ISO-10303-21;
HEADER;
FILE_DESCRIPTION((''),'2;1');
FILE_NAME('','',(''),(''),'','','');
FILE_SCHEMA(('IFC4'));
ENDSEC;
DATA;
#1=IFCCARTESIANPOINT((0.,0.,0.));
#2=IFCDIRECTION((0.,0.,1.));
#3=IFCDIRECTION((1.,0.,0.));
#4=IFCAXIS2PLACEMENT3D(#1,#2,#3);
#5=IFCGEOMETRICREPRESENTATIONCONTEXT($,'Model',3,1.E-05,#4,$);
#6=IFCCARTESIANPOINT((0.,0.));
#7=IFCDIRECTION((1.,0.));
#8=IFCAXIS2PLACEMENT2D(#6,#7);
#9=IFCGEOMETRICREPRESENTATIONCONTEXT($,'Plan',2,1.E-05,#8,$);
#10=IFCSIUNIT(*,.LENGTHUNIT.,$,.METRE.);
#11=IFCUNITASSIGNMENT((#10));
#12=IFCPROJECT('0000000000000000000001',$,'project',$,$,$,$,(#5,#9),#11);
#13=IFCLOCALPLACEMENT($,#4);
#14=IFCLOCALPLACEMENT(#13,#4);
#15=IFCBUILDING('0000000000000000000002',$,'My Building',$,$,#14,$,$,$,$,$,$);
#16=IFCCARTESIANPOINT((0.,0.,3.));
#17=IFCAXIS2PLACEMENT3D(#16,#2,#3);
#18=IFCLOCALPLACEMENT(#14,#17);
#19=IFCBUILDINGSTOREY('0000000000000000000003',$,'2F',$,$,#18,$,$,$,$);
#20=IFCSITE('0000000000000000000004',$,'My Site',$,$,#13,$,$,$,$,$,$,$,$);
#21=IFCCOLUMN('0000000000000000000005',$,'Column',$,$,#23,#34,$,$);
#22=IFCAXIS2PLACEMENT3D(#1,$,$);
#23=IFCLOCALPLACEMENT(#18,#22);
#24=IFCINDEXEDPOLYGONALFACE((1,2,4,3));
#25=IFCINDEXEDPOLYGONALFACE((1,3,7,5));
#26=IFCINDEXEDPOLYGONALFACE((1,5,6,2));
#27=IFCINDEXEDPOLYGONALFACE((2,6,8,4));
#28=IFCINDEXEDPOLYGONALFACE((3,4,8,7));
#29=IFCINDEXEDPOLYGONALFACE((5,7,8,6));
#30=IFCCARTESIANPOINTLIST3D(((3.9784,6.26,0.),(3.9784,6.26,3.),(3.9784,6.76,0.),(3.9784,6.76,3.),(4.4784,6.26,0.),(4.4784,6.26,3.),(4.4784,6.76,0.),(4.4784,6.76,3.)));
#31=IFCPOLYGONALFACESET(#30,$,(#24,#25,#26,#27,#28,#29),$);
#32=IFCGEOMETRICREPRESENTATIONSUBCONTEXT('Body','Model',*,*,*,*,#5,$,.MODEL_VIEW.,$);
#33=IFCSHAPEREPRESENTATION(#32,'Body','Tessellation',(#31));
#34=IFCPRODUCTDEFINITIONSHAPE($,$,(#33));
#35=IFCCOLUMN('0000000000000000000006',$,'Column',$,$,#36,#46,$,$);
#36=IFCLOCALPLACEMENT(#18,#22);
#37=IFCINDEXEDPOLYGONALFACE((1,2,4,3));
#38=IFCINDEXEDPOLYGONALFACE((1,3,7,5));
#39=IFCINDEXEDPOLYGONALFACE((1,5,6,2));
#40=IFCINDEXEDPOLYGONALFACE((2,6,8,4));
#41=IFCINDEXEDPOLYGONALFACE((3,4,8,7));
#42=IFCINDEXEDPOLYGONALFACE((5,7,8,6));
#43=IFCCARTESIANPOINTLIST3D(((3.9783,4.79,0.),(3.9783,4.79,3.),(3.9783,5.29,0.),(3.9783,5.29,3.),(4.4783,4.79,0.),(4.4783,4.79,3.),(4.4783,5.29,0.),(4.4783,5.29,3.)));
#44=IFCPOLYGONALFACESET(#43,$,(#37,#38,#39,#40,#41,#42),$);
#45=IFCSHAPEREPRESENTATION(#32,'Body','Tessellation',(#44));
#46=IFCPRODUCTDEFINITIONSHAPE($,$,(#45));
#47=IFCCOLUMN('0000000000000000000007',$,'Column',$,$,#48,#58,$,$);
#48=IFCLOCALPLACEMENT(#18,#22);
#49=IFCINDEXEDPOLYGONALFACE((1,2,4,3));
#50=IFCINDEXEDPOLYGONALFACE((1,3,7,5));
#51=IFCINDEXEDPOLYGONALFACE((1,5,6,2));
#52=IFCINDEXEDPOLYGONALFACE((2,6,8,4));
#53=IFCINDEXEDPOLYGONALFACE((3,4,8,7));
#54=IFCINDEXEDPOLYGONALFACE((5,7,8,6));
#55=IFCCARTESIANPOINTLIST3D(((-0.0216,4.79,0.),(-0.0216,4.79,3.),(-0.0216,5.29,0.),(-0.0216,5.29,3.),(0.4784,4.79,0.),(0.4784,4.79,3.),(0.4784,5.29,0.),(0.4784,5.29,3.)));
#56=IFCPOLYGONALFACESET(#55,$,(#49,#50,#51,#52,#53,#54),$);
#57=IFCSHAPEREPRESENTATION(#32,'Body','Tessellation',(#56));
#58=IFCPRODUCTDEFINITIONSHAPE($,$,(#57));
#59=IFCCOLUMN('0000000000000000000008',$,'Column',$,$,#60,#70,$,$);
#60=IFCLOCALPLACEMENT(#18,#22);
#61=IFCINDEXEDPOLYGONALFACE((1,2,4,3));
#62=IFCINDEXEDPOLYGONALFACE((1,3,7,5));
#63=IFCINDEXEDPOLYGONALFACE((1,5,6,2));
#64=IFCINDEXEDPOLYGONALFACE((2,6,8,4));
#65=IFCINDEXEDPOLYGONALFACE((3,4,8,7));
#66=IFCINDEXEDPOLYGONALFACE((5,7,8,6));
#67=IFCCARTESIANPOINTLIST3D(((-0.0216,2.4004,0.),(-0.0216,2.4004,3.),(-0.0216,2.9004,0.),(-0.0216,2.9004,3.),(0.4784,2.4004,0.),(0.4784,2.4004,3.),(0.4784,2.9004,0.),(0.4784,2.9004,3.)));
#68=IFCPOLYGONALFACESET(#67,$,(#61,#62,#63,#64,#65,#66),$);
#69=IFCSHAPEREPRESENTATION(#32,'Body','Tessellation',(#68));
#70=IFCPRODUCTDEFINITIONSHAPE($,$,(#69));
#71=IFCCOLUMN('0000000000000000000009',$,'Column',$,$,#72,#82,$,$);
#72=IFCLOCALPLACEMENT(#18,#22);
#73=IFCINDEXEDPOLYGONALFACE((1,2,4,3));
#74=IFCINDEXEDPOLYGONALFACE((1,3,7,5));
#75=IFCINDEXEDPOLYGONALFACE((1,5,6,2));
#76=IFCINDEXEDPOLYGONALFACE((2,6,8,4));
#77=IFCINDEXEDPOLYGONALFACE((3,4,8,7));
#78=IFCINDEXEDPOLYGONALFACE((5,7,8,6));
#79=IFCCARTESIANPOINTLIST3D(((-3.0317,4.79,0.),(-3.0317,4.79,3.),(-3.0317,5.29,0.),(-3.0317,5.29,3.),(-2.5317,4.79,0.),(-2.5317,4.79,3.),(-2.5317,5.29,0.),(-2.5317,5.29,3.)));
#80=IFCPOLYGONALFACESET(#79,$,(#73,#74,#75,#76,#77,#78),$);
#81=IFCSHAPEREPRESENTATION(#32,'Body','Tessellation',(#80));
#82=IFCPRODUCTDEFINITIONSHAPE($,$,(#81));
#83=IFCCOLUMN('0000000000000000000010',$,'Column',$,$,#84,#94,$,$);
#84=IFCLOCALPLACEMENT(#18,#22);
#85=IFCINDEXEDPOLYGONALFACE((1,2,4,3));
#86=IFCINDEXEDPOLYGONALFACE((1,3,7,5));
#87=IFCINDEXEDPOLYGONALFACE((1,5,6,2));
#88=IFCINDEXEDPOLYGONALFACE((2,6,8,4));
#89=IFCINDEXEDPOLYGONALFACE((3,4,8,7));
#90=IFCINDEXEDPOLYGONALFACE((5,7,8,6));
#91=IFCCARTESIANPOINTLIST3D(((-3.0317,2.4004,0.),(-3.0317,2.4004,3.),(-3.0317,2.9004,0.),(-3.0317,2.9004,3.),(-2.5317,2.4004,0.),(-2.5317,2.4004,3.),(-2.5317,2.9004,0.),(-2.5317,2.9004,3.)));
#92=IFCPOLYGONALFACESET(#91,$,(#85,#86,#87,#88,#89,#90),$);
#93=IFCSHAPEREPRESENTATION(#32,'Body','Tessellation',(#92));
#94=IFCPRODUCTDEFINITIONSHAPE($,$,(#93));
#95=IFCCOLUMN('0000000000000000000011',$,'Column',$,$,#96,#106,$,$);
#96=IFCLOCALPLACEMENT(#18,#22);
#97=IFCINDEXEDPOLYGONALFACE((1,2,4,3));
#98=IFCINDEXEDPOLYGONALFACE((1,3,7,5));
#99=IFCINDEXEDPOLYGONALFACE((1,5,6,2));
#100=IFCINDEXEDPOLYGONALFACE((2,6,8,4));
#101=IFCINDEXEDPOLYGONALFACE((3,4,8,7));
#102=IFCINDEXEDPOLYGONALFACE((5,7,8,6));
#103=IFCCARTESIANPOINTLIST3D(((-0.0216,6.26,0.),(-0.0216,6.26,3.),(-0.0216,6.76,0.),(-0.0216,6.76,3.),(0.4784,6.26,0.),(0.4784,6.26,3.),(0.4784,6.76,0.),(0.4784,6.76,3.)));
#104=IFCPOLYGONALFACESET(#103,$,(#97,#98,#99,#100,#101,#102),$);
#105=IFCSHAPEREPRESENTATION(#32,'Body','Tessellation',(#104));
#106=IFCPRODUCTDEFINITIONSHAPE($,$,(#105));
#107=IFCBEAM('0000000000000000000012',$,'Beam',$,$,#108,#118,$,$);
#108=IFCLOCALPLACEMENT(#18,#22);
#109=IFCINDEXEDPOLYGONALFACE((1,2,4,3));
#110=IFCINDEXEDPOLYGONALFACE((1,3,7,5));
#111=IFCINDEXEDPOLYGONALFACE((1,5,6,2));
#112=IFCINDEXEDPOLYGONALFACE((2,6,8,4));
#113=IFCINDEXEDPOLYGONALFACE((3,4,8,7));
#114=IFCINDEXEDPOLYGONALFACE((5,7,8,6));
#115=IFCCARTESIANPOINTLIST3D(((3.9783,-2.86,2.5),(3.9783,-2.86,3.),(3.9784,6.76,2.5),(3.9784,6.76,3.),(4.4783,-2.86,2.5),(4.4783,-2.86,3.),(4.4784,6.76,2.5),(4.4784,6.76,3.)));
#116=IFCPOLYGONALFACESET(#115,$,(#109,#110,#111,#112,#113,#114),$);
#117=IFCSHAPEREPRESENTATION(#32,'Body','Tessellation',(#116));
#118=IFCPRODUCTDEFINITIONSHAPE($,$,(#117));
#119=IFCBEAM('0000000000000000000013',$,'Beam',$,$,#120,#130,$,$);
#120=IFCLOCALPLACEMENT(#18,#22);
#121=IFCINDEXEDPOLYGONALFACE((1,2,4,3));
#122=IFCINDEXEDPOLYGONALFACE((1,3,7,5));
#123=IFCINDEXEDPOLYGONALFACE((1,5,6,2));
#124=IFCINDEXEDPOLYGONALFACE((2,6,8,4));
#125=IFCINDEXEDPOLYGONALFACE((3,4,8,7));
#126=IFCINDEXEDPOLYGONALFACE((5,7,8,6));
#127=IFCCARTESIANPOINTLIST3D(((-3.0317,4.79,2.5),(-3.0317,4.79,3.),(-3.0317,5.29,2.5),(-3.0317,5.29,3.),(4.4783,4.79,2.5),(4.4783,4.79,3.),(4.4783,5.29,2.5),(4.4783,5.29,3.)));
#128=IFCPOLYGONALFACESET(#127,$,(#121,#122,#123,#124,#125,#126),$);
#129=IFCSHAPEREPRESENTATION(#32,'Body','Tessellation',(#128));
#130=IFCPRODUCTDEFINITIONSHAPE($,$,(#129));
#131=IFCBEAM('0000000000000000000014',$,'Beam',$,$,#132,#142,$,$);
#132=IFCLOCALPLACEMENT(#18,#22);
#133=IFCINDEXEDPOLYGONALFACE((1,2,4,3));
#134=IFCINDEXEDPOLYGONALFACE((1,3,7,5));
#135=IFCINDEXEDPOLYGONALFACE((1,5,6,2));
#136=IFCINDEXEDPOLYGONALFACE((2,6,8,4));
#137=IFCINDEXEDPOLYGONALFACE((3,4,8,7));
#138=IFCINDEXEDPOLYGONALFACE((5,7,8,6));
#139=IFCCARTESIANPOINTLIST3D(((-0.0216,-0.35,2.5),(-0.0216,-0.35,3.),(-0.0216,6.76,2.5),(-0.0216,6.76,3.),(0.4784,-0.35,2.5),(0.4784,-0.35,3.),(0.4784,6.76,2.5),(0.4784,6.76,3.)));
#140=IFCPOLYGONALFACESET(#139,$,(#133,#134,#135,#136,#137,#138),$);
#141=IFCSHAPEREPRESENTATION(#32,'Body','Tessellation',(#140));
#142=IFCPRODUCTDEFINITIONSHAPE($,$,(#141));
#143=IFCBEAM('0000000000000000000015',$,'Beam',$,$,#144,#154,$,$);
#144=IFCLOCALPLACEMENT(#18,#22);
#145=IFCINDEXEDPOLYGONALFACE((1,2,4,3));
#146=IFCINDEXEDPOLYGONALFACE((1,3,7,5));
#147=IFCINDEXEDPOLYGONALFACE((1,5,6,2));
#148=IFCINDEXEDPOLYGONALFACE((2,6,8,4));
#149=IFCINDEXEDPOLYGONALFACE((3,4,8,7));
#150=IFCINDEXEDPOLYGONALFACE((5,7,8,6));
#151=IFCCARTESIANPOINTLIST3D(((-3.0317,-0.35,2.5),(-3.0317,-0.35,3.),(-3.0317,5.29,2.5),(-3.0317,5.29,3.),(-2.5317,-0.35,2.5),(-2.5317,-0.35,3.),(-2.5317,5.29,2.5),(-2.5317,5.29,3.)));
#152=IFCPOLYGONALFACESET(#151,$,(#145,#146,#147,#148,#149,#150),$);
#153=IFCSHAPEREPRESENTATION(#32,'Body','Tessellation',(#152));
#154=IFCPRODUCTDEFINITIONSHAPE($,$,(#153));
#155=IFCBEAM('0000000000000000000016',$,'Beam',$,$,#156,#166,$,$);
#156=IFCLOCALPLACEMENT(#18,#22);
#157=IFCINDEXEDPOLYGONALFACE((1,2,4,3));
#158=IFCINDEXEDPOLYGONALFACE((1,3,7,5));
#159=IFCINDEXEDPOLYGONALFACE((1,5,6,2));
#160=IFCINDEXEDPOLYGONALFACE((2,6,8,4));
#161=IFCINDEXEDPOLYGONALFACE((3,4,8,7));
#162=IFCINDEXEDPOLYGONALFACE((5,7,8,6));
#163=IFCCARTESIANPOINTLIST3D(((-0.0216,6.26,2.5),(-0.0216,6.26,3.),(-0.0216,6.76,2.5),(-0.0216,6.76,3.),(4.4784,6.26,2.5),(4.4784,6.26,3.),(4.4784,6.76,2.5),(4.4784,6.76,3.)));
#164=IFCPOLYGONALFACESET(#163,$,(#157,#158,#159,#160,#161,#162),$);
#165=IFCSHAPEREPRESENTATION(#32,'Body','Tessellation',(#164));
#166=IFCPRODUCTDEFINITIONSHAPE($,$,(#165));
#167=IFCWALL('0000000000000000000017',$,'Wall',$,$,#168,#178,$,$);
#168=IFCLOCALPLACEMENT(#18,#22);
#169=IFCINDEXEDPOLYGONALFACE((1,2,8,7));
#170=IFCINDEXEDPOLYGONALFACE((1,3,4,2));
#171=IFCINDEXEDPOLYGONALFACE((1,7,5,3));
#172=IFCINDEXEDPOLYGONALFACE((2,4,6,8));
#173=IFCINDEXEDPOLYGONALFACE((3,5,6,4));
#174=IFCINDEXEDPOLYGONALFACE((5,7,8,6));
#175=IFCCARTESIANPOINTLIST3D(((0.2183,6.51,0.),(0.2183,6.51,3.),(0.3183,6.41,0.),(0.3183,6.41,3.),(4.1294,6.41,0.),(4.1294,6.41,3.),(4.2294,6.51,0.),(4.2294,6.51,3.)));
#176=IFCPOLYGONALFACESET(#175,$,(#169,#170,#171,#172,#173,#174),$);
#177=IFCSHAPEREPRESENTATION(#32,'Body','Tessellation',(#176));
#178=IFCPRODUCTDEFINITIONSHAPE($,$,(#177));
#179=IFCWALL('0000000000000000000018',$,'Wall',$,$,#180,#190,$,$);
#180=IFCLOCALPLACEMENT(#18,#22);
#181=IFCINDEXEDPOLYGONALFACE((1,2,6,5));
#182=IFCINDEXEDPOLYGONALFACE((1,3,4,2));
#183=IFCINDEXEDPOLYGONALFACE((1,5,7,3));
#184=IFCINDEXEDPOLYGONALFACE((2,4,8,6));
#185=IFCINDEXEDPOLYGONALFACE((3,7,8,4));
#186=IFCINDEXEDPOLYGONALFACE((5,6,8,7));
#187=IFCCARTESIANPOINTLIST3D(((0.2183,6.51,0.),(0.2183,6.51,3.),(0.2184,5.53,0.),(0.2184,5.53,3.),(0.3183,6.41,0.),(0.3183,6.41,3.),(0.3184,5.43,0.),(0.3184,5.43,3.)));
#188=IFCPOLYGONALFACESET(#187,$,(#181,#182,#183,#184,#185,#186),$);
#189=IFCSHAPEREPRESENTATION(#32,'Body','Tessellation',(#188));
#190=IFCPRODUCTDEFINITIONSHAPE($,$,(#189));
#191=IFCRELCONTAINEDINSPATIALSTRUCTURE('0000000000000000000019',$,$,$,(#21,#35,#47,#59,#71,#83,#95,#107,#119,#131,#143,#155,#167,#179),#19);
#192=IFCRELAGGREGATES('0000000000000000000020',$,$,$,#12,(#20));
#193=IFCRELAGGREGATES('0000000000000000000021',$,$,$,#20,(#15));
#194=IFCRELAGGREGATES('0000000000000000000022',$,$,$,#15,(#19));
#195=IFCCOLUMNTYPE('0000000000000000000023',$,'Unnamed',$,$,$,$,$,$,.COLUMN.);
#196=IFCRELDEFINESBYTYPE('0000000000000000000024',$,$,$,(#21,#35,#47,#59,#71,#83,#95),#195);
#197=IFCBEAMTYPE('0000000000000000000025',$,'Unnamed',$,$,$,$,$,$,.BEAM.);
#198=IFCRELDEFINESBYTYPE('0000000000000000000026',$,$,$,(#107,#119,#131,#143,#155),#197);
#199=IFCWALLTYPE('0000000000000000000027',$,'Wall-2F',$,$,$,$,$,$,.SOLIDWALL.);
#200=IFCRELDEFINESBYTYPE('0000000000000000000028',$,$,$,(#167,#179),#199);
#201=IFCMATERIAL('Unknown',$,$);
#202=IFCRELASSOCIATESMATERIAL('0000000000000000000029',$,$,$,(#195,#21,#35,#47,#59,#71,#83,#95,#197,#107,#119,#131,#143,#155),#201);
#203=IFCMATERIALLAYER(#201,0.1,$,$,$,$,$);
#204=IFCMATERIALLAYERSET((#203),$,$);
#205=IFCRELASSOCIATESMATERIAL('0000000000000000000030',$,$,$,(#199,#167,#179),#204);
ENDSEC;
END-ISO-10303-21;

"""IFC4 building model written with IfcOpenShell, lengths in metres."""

from ifc_helpers import new_model, si_unit, frame, origin_with_axes, origin_2d_with_axis, place, context, subcontext, project, spatial, line, indexed_curve, rectangle, outline, extrude, material, layer, layer_set, layer_usage, material_profile, profile_set, profile_usage, type_object, element, save


model = new_model("IFC4")

# Units and contexts
model_context = context("Model", 3, precision=1e-05, world=origin_with_axes())
plan_context = context("Plan", 2, precision=1e-05, world=origin_2d_with_axis())
body_context_1 = subcontext(model_context, "Body", "Model", "MODEL_VIEW")
ifc_project = project(units=[si_unit("LENGTHUNIT", "METRE")], contexts=[model_context, plan_context])

# Site, building, storey
site_placement = place(None, origin_with_axes())
site = spatial("IfcSite", under=ifc_project, at=site_placement, Name="My Site")
building_placement = place(site_placement, origin_with_axes())
building = spatial("IfcBuilding", under=site, at=building_placement, Name="My Building")
storey_placement = place(building_placement, frame((0.0, 0.0, 3.0), z_axis=(0.0, 0.0, 1.0), x_axis=(1.0, 0.0, 0.0)))
storey = spatial("IfcBuildingStorey", under=building, at=storey_placement, Name="2F")

# Columns
ifc_material = material(Name="Unknown")
ifc_material_profile_1 = material_profile(ifc_material, rectangle(XDim=0.5, YDim=0.5))
ifc_profile_set_1 = profile_set([ifc_material_profile_1])
ifc_profile_usage_1 = profile_usage(ifc_profile_set_1, cardinal=7)
column_type = type_object("IfcColumnType", Name="Unnamed", PredefinedType="COLUMN", material=ifc_profile_set_1)
column_1_placement = place(storey_placement, frame((4.4784, 6.76, 0.0), z_axis=(0.0, 0.0, 1.0), x_axis=(1.0, 0.0, 0.0)))
element("IfcColumn", 1, at=column_1_placement, inside=storey, type_object=column_type, material=ifc_profile_usage_1, Name="Column", context=body_context_1, shape_type="SweptSolid", body=[
    extrude(rectangle(XDim=0.5, YDim=0.5), frame((-0.25, -0.25, 0.0), z_axis=(0.0, 0.0, 1.0), x_axis=(1.0, 0.0, 0.0)), (0.0, 0.0, 1.0), 3.0),
])
ifc_profile_usage_2 = profile_usage(ifc_profile_set_1, cardinal=7)
column_2_placement = place(storey_placement, frame((4.4783, 5.29, 0.0), z_axis=(0.0, 0.0, 1.0), x_axis=(1.0, 0.0, 0.0)))
element("IfcColumn", 2, at=column_2_placement, inside=storey, type_object=column_type, material=ifc_profile_usage_2, Name="Column", context=body_context_1, shape_type="SweptSolid", body=[
    extrude(rectangle(XDim=0.5, YDim=0.5), frame((-0.25, -0.25, 0.0), z_axis=(0.0, 0.0, 1.0), x_axis=(1.0, 0.0, 0.0)), (0.0, 0.0, 1.0), 3.0),
])
ifc_profile_usage_3 = profile_usage(ifc_profile_set_1, cardinal=7)
column_3_placement = place(storey_placement, frame((0.4784, 5.29, 0.0), z_axis=(0.0, 0.0, 1.0), x_axis=(1.0, 0.0, 0.0)))
element("IfcColumn", 3, at=column_3_placement, inside=storey, type_object=column_type, material=ifc_profile_usage_3, Name="Column", context=body_context_1, shape_type="SweptSolid", body=[
    extrude(rectangle(XDim=0.5, YDim=0.5), frame((-0.25, -0.25, 0.0), z_axis=(0.0, 0.0, 1.0), x_axis=(1.0, 0.0, 0.0)), (0.0, 0.0, 1.0), 3.0),
])
ifc_profile_usage_4 = profile_usage(ifc_profile_set_1, cardinal=7)
column_4_placement = place(storey_placement, frame((0.4784, 2.9004, 0.0), z_axis=(0.0, 0.0, 1.0), x_axis=(1.0, 0.0, 0.0)))
element("IfcColumn", 4, at=column_4_placement, inside=storey, type_object=column_type, material=ifc_profile_usage_4, Name="Column", context=body_context_1, shape_type="SweptSolid", body=[
    extrude(rectangle(XDim=0.5, YDim=0.5), frame((-0.25, -0.25, 0.0), z_axis=(0.0, 0.0, 1.0), x_axis=(1.0, 0.0, 0.0)), (0.0, 0.0, 1.0), 3.0),
])
ifc_profile_usage_5 = profile_usage(ifc_profile_set_1, cardinal=7)
column_5_placement = place(storey_placement, frame((-2.5317, 5.29, 0.0), z_axis=(0.0, 0.0, 1.0), x_axis=(1.0, 0.0, 0.0)))
element("IfcColumn", 5, at=column_5_placement, inside=storey, type_object=column_type, material=ifc_profile_usage_5, Name="Column", context=body_context_1, shape_type="SweptSolid", body=[
    extrude(rectangle(XDim=0.5, YDim=0.5), frame((-0.25, -0.25, 0.0), z_axis=(0.0, 0.0, 1.0), x_axis=(1.0, 0.0, 0.0)), (0.0, 0.0, 1.0), 3.0),
])
ifc_profile_usage_6 = profile_usage(ifc_profile_set_1, cardinal=7)
column_6_placement = place(storey_placement, frame((-2.5317, 2.9004, 0.0), z_axis=(0.0, 0.0, 1.0), x_axis=(1.0, 0.0, 0.0)))
element("IfcColumn", 6, at=column_6_placement, inside=storey, type_object=column_type, material=ifc_profile_usage_6, Name="Column", context=body_context_1, shape_type="SweptSolid", body=[
    extrude(rectangle(XDim=0.5, YDim=0.5), frame((-0.25, -0.25, 0.0), z_axis=(0.0, 0.0, 1.0), x_axis=(1.0, 0.0, 0.0)), (0.0, 0.0, 1.0), 3.0),
])
ifc_profile_usage_7 = profile_usage(ifc_profile_set_1, cardinal=7)
column_7_placement = place(storey_placement, frame((0.4784, 6.76, 0.0), z_axis=(0.0, 0.0, 1.0), x_axis=(1.0, 0.0, 0.0)))
element("IfcColumn", 7, at=column_7_placement, inside=storey, type_object=column_type, material=ifc_profile_usage_7, Name="Column", context=body_context_1, shape_type="SweptSolid", body=[
    extrude(rectangle(XDim=0.5, YDim=0.5), frame((-0.25, -0.25, 0.0), z_axis=(0.0, 0.0, 1.0), x_axis=(1.0, 0.0, 0.0)), (0.0, 0.0, 1.0), 3.0),
])

# Beams
ifc_material_profile_2 = material_profile(ifc_material, rectangle(XDim=0.5, YDim=0.5))
ifc_profile_set_2 = profile_set([ifc_material_profile_2])
ifc_profile_usage_8 = profile_usage(ifc_profile_set_2, cardinal=7)
beam_type = type_object("IfcBeamType", Name="Unnamed", PredefinedType="BEAM", material=ifc_profile_set_2)
beam_1_placement = place(storey_placement, frame((4.4784, 6.76, 3.0), z_axis=(0.0, -1.0, 0.0), x_axis=(1.0, 0.0, 0.0)))
element("IfcBeam", 8, at=beam_1_placement, inside=storey, type_object=beam_type, material=ifc_profile_usage_8, Name="Beam", context=body_context_1, shape_type="SweptSolid", body=[
    extrude(rectangle(XDim=0.5, YDim=0.5), frame((-0.25, -0.25, 0.0), z_axis=(0.0, 0.0, 1.0), x_axis=(1.0, 0.0, 0.0)), (0.0, 0.0, 1.0), 9.62),
])
ifc_profile_usage_9 = profile_usage(ifc_profile_set_2, cardinal=7)
beam_2_placement = place(storey_placement, frame((4.4783, 4.79, 3.0), z_axis=(-1.0, 0.0, 0.0), x_axis=(0.0, -1.0, 0.0)))
element("IfcBeam", 9, at=beam_2_placement, inside=storey, type_object=beam_type, material=ifc_profile_usage_9, Name="Beam", context=body_context_1, shape_type="SweptSolid", body=[
    extrude(rectangle(XDim=0.5, YDim=0.5), frame((-0.25, -0.25, 0.0), z_axis=(0.0, 0.0, 1.0), x_axis=(1.0, 0.0, 0.0)), (0.0, 0.0, 1.0), 7.51),
])
ifc_profile_usage_10 = profile_usage(ifc_profile_set_2, cardinal=7)
beam_3_placement = place(storey_placement, frame((0.4784, 6.76, 3.0), z_axis=(0.0, -1.0, 0.0), x_axis=(1.0, 0.0, 0.0)))
element("IfcBeam", 10, at=beam_3_placement, inside=storey, type_object=beam_type, material=ifc_profile_usage_10, Name="Beam", context=body_context_1, shape_type="SweptSolid", body=[
    extrude(rectangle(XDim=0.5, YDim=0.5), frame((-0.25, -0.25, 0.0), z_axis=(0.0, 0.0, 1.0), x_axis=(1.0, 0.0, 0.0)), (0.0, 0.0, 1.0), 7.11),
])
ifc_profile_usage_11 = profile_usage(ifc_profile_set_2, cardinal=7)
beam_4_placement = place(storey_placement, frame((-2.5317, 5.29, 3.0), z_axis=(0.0, -1.0, 0.0), x_axis=(1.0, 0.0, 0.0)))
element("IfcBeam", 11, at=beam_4_placement, inside=storey, type_object=beam_type, material=ifc_profile_usage_11, Name="Beam", context=body_context_1, shape_type="SweptSolid", body=[
    extrude(rectangle(XDim=0.5, YDim=0.5), frame((-0.25, -0.25, 0.0), z_axis=(0.0, 0.0, 1.0), x_axis=(1.0, 0.0, 0.0)), (0.0, 0.0, 1.0), 5.64),
])
ifc_profile_usage_12 = profile_usage(ifc_profile_set_2, cardinal=7)
beam_5_placement = place(storey_placement, frame((4.4784, 6.26, 3.0), z_axis=(-1.0, 0.0, 0.0), x_axis=(0.0, -1.0, 0.0)))
element("IfcBeam", 12, at=beam_5_placement, inside=storey, type_object=beam_type, material=ifc_profile_usage_12, Name="Beam", context=body_context_1, shape_type="SweptSolid", body=[
    extrude(rectangle(XDim=0.5, YDim=0.5), frame((-0.25, -0.25, 0.0), z_axis=(0.0, 0.0, 1.0), x_axis=(1.0, 0.0, 0.0)), (0.0, 0.0, 1.0), 4.5),
])

# Walls
ifc_layer = layer(ifc_material, 0.1)
ifc_layer_set = layer_set([ifc_layer])
ifc_layer_usage_1 = layer_usage(ifc_layer_set, "AXIS2", "POSITIVE", 0.0)
wall_type = type_object("IfcWallType", Name="Wall-2F", PredefinedType="SOLIDWALL", material=ifc_layer_set)
wall_1_placement = place(storey_placement, frame((4.2294, 6.51, 0.0), z_axis=(0.0, 0.0, 1.0), x_axis=(-1.0, 0.0, 0.0)))
element("IfcWall", 13, at=wall_1_placement, inside=storey, type_object=wall_type, material=ifc_layer_usage_1, Name="Wall", context=body_context_1, shape_type="SweptSolid", body=[
    extrude(outline(indexed_curve([(0.0, 0.0), (0.1, 0.1), (3.9111, 0.1), (4.0111, 0.0)], segments=[line(1, 2, 3, 4, 1)])), origin_with_axes(), (0.0, 0.0, 1.0), 3.0),
])
ifc_layer_usage_2 = layer_usage(ifc_layer_set, "AXIS2", "POSITIVE", 0.0)
wall_2_placement = place(storey_placement, frame((0.2183, 6.51, 0.0), z_axis=(0.0, 0.0, 1.0), x_axis=(0.0, -1.0, 0.0)))
element("IfcWall", 14, at=wall_2_placement, inside=storey, type_object=wall_type, material=ifc_layer_usage_2, Name="Wall", context=body_context_1, shape_type="SweptSolid", body=[
    extrude(outline(indexed_curve([(0.0, 0.0), (0.1, 0.1), (1.08, 0.1), (0.98, 0.0)], segments=[line(1, 2, 3, 4, 1)])), origin_with_axes(), (0.0, 0.0, 1.0), 3.0),
])

save(model, "model.ifc")
